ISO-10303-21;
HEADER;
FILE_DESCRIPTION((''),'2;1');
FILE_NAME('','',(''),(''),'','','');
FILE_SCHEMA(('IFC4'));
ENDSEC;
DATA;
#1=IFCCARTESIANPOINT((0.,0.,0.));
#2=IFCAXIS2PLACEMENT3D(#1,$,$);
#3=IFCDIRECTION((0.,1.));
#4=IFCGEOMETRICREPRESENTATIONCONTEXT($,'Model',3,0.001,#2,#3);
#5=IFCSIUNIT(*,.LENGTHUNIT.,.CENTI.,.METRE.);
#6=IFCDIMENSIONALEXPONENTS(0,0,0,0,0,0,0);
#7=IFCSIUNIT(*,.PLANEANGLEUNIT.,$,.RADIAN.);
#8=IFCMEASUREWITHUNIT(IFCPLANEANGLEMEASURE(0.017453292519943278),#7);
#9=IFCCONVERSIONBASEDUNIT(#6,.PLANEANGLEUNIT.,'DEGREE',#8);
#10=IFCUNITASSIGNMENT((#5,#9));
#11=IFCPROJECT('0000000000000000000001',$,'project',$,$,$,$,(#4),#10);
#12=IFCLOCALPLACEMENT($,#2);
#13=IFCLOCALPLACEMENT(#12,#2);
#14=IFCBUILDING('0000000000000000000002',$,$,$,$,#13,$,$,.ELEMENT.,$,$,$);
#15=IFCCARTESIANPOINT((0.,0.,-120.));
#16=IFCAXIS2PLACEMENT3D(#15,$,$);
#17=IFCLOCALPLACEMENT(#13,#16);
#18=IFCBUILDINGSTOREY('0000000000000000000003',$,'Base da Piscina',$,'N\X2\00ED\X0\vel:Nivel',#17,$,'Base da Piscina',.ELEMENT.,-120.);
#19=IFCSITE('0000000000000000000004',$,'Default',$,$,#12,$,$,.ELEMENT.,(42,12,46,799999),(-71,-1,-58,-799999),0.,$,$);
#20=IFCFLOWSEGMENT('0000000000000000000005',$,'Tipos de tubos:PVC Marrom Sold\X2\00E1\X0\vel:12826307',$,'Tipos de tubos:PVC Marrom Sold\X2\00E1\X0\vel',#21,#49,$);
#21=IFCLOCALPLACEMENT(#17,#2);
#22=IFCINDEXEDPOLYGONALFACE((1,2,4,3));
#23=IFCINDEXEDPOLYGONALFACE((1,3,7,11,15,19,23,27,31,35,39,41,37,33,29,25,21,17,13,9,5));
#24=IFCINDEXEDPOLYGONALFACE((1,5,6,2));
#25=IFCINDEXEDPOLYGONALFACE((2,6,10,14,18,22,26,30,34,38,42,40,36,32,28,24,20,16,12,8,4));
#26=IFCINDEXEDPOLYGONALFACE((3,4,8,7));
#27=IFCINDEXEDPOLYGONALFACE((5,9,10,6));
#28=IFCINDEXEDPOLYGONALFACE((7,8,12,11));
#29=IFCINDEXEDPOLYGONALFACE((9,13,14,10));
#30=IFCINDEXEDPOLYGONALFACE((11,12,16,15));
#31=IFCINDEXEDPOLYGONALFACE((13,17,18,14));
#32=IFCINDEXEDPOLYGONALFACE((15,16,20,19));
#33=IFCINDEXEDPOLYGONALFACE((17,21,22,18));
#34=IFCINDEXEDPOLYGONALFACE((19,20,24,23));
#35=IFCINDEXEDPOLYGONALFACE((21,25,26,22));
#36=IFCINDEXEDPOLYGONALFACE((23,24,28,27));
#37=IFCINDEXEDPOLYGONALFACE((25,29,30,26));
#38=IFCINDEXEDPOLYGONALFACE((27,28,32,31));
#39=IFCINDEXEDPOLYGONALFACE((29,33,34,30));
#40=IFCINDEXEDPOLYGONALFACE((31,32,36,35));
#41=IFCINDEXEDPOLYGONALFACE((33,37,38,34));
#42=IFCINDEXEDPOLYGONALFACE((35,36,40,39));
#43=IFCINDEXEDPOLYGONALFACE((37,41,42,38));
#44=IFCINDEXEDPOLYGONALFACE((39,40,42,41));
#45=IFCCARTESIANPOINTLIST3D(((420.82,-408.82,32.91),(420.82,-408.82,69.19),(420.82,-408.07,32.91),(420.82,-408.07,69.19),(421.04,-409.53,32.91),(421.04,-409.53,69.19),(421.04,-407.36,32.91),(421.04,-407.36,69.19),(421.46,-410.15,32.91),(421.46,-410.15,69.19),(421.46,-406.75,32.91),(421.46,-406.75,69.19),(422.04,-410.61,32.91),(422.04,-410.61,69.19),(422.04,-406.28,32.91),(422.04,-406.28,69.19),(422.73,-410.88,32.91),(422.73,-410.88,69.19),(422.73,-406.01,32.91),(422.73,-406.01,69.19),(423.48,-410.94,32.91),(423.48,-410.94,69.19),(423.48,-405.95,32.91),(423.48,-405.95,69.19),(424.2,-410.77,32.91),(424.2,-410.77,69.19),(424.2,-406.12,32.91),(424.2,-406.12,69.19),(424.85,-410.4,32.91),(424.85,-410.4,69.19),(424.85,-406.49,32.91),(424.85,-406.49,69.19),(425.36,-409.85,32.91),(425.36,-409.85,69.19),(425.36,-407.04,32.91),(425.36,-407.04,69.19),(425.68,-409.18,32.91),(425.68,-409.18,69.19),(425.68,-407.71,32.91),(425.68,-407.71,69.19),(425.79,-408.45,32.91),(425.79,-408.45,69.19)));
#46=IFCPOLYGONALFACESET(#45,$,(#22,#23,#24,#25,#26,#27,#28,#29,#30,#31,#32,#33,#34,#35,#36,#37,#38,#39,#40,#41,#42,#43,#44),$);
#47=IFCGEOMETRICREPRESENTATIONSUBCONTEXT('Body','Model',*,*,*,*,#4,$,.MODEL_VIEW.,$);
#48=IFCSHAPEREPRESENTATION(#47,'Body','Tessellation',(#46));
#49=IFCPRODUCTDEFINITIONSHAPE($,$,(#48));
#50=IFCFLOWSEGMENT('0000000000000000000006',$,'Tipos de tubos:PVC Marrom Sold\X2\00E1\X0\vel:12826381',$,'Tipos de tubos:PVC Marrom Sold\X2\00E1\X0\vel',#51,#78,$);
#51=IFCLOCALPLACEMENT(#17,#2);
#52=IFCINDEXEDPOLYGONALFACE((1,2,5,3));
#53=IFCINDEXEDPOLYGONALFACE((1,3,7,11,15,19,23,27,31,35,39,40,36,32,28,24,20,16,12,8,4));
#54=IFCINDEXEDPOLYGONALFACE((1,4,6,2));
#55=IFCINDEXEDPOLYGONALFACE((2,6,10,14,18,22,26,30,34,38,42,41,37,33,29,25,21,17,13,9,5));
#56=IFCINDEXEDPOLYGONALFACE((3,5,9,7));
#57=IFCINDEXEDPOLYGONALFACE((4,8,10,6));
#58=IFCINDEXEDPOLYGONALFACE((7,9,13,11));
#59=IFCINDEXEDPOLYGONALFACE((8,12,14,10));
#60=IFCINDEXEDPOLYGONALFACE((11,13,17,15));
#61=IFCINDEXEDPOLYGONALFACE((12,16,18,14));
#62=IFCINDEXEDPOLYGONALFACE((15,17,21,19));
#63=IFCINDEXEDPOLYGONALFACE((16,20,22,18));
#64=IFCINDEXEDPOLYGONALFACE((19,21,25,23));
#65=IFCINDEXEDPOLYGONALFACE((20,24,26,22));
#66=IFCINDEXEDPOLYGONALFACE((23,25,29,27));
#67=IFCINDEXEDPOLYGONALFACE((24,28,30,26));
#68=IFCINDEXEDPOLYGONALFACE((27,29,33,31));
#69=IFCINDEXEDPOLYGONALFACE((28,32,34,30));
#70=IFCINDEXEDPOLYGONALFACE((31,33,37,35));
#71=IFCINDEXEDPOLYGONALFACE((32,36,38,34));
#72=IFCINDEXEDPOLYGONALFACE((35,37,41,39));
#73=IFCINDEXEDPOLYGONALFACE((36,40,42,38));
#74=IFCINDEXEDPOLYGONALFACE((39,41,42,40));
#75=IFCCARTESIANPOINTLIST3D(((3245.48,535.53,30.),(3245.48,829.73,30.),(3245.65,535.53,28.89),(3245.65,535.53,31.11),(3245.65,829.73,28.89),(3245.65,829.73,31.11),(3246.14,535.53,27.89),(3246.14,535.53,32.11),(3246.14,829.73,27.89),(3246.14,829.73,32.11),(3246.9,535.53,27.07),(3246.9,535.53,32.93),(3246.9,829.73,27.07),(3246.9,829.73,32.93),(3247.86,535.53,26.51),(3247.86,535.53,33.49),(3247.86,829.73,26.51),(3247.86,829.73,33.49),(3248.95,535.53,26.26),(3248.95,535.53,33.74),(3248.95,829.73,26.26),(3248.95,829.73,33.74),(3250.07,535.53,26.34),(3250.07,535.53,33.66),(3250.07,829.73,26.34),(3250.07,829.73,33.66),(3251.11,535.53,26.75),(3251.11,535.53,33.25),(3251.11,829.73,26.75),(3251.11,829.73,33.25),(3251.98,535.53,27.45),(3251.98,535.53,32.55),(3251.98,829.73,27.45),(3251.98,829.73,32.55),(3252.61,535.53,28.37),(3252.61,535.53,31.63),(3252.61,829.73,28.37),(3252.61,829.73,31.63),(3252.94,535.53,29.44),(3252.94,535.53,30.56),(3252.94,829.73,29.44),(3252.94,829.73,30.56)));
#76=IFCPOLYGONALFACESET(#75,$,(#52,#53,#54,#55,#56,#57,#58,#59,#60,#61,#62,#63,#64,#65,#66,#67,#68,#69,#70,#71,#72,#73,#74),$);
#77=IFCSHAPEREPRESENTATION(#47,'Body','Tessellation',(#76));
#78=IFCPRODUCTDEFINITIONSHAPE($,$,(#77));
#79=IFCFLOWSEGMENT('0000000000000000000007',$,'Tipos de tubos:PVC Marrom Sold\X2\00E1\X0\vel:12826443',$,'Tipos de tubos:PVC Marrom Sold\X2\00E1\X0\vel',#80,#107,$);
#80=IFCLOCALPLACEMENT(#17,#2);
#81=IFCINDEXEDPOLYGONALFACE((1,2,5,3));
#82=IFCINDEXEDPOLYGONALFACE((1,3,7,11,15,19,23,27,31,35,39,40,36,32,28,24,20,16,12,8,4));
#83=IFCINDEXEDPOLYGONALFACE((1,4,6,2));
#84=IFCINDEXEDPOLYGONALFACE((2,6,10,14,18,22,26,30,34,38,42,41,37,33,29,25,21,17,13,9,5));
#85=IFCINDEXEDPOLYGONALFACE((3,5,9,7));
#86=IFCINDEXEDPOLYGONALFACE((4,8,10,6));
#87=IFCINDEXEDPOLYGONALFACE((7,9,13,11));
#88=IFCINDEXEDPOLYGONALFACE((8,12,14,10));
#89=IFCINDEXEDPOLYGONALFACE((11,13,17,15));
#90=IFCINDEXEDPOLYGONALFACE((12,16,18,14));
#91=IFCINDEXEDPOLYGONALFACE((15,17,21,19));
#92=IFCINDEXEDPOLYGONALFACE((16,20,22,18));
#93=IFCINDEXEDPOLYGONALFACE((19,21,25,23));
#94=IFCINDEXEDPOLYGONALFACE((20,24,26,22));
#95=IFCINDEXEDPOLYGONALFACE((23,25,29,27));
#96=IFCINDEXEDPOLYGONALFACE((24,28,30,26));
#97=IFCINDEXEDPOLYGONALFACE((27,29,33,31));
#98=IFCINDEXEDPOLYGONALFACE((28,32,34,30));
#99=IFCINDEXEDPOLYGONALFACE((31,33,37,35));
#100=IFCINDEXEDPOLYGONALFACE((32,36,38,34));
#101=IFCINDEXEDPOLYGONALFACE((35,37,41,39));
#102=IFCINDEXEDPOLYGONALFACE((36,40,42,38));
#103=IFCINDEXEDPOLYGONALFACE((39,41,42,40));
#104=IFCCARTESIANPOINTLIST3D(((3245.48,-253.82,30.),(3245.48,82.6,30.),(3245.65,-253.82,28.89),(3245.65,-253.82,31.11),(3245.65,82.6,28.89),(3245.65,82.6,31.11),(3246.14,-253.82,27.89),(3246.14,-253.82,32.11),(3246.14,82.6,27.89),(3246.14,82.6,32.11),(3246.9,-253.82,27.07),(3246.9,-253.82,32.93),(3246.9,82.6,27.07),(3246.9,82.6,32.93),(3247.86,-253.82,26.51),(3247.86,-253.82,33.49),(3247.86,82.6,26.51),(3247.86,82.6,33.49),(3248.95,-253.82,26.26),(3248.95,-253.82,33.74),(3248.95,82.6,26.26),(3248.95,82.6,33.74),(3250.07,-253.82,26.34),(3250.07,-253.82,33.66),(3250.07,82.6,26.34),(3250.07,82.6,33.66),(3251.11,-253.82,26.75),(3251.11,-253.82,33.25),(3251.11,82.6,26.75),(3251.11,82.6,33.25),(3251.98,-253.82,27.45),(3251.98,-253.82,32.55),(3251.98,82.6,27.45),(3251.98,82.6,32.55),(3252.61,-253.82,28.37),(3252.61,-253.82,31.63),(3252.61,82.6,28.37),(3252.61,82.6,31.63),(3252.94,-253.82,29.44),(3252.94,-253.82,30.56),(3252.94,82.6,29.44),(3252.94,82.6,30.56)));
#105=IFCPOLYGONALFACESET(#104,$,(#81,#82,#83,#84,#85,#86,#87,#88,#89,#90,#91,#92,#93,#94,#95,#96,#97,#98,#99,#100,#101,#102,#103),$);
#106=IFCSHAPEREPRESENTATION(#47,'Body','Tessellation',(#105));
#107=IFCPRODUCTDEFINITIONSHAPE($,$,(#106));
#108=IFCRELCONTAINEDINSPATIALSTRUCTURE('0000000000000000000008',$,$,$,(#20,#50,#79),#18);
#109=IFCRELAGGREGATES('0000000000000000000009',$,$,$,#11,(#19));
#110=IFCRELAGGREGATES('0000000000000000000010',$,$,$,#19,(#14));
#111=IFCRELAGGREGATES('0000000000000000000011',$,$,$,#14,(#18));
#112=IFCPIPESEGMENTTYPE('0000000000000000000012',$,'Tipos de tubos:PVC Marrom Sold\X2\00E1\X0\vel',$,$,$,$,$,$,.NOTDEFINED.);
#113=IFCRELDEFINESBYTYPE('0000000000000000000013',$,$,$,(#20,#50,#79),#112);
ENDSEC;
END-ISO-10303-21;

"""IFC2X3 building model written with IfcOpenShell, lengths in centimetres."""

from ifc_helpers import new_model, entity, si_unit, converted_unit, direction, frame, frame_2d, origin, origin_2d_with_axis, place, context, subcontext, project, spatial, circle, extrude, type_object, element, save


model = new_model("IFC2X3")

# Units and contexts
model_context = context("Model", 3, precision=0.001, world=origin(), true_north=direction((0.0, 1.0)))
body_context = subcontext(model_context, "Body", "Model", "MODEL_VIEW")
ifc_project = project(units=[si_unit("LENGTHUNIT", "METRE", prefix="CENTI"), converted_unit("PLANEANGLEUNIT", "DEGREE", entity("IfcPlaneAngleMeasure", 0.017453292519943278), si_unit("PLANEANGLEUNIT", "RADIAN"), dimensions=[0, 0, 0, 0, 0, 0, 0])], contexts=[model_context])

# Site, building, storey
site_placement = place(None, origin())
site = spatial("IfcSite", under=ifc_project, at=site_placement, Name="Default", CompositionType="ELEMENT", RefLatitude=(42, 12, 46, 799999), RefLongitude=(-71, -1, -58, -799999), RefElevation=0.0)
building_placement = place(site_placement, origin())
building = spatial("IfcBuilding", under=site, at=building_placement, CompositionType="ELEMENT")
storey_placement = place(building_placement, frame((0.0, 0.0, -120.0)))
storey = spatial("IfcBuildingStorey", under=building, at=storey_placement, Name="Base da Piscina", ObjectType="Nível:Nivel", LongName="Base da Piscina", CompositionType="ELEMENT", Elevation=-120.0)

# Flow segments
pipe_segment_type = type_object("IfcPipeSegmentType", Name="Tipos de tubos:PVC Marrom Soldável", PredefinedType="NOTDEFINED")
flow_segment_1_placement = place(storey_placement, origin())
element("IfcFlowSegment", 1, at=flow_segment_1_placement, inside=storey, type_object=pipe_segment_type, Name="Tipos de tubos:PVC Marrom Soldável:12826307", ObjectType="Tipos de tubos:PVC Marrom Soldável", context=body_context, shape_type="SweptSolid", body=[
    extrude(circle(Radius=2.5, at=frame_2d((0.0, 0.0), x_axis=(1.0, 0.0))), frame((423.29, -408.45, 32.91)), (0.0, 0.0, 1.0), 36.28),
])
flow_segment_2_placement = place(storey_placement, origin())
element("IfcFlowSegment", 2, at=flow_segment_2_placement, inside=storey, type_object=pipe_segment_type, Name="Tipos de tubos:PVC Marrom Soldável:12826381", ObjectType="Tipos de tubos:PVC Marrom Soldável", context=body_context, shape_type="SweptSolid", body=[
    extrude(circle(Radius=3.75, at=origin_2d_with_axis()), frame((3249.23, 535.53, 30.0), z_axis=(0.0, 1.0, 0.0), x_axis=(-1.0, 0.0, 0.0)), (0.0, 0.0, 1.0), 294.2),
])
flow_segment_3_placement = place(storey_placement, origin())
element("IfcFlowSegment", 3, at=flow_segment_3_placement, inside=storey, type_object=pipe_segment_type, Name="Tipos de tubos:PVC Marrom Soldável:12826443", ObjectType="Tipos de tubos:PVC Marrom Soldável", context=body_context, shape_type="SweptSolid", body=[
    extrude(circle(Radius=3.75, at=origin_2d_with_axis()), frame((3249.23, -253.82, 30.0), z_axis=(0.0, 1.0, 0.0), x_axis=(-1.0, 0.0, 0.0)), (0.0, 0.0, 1.0), 336.42),
])

save(model, "model.ifc")
